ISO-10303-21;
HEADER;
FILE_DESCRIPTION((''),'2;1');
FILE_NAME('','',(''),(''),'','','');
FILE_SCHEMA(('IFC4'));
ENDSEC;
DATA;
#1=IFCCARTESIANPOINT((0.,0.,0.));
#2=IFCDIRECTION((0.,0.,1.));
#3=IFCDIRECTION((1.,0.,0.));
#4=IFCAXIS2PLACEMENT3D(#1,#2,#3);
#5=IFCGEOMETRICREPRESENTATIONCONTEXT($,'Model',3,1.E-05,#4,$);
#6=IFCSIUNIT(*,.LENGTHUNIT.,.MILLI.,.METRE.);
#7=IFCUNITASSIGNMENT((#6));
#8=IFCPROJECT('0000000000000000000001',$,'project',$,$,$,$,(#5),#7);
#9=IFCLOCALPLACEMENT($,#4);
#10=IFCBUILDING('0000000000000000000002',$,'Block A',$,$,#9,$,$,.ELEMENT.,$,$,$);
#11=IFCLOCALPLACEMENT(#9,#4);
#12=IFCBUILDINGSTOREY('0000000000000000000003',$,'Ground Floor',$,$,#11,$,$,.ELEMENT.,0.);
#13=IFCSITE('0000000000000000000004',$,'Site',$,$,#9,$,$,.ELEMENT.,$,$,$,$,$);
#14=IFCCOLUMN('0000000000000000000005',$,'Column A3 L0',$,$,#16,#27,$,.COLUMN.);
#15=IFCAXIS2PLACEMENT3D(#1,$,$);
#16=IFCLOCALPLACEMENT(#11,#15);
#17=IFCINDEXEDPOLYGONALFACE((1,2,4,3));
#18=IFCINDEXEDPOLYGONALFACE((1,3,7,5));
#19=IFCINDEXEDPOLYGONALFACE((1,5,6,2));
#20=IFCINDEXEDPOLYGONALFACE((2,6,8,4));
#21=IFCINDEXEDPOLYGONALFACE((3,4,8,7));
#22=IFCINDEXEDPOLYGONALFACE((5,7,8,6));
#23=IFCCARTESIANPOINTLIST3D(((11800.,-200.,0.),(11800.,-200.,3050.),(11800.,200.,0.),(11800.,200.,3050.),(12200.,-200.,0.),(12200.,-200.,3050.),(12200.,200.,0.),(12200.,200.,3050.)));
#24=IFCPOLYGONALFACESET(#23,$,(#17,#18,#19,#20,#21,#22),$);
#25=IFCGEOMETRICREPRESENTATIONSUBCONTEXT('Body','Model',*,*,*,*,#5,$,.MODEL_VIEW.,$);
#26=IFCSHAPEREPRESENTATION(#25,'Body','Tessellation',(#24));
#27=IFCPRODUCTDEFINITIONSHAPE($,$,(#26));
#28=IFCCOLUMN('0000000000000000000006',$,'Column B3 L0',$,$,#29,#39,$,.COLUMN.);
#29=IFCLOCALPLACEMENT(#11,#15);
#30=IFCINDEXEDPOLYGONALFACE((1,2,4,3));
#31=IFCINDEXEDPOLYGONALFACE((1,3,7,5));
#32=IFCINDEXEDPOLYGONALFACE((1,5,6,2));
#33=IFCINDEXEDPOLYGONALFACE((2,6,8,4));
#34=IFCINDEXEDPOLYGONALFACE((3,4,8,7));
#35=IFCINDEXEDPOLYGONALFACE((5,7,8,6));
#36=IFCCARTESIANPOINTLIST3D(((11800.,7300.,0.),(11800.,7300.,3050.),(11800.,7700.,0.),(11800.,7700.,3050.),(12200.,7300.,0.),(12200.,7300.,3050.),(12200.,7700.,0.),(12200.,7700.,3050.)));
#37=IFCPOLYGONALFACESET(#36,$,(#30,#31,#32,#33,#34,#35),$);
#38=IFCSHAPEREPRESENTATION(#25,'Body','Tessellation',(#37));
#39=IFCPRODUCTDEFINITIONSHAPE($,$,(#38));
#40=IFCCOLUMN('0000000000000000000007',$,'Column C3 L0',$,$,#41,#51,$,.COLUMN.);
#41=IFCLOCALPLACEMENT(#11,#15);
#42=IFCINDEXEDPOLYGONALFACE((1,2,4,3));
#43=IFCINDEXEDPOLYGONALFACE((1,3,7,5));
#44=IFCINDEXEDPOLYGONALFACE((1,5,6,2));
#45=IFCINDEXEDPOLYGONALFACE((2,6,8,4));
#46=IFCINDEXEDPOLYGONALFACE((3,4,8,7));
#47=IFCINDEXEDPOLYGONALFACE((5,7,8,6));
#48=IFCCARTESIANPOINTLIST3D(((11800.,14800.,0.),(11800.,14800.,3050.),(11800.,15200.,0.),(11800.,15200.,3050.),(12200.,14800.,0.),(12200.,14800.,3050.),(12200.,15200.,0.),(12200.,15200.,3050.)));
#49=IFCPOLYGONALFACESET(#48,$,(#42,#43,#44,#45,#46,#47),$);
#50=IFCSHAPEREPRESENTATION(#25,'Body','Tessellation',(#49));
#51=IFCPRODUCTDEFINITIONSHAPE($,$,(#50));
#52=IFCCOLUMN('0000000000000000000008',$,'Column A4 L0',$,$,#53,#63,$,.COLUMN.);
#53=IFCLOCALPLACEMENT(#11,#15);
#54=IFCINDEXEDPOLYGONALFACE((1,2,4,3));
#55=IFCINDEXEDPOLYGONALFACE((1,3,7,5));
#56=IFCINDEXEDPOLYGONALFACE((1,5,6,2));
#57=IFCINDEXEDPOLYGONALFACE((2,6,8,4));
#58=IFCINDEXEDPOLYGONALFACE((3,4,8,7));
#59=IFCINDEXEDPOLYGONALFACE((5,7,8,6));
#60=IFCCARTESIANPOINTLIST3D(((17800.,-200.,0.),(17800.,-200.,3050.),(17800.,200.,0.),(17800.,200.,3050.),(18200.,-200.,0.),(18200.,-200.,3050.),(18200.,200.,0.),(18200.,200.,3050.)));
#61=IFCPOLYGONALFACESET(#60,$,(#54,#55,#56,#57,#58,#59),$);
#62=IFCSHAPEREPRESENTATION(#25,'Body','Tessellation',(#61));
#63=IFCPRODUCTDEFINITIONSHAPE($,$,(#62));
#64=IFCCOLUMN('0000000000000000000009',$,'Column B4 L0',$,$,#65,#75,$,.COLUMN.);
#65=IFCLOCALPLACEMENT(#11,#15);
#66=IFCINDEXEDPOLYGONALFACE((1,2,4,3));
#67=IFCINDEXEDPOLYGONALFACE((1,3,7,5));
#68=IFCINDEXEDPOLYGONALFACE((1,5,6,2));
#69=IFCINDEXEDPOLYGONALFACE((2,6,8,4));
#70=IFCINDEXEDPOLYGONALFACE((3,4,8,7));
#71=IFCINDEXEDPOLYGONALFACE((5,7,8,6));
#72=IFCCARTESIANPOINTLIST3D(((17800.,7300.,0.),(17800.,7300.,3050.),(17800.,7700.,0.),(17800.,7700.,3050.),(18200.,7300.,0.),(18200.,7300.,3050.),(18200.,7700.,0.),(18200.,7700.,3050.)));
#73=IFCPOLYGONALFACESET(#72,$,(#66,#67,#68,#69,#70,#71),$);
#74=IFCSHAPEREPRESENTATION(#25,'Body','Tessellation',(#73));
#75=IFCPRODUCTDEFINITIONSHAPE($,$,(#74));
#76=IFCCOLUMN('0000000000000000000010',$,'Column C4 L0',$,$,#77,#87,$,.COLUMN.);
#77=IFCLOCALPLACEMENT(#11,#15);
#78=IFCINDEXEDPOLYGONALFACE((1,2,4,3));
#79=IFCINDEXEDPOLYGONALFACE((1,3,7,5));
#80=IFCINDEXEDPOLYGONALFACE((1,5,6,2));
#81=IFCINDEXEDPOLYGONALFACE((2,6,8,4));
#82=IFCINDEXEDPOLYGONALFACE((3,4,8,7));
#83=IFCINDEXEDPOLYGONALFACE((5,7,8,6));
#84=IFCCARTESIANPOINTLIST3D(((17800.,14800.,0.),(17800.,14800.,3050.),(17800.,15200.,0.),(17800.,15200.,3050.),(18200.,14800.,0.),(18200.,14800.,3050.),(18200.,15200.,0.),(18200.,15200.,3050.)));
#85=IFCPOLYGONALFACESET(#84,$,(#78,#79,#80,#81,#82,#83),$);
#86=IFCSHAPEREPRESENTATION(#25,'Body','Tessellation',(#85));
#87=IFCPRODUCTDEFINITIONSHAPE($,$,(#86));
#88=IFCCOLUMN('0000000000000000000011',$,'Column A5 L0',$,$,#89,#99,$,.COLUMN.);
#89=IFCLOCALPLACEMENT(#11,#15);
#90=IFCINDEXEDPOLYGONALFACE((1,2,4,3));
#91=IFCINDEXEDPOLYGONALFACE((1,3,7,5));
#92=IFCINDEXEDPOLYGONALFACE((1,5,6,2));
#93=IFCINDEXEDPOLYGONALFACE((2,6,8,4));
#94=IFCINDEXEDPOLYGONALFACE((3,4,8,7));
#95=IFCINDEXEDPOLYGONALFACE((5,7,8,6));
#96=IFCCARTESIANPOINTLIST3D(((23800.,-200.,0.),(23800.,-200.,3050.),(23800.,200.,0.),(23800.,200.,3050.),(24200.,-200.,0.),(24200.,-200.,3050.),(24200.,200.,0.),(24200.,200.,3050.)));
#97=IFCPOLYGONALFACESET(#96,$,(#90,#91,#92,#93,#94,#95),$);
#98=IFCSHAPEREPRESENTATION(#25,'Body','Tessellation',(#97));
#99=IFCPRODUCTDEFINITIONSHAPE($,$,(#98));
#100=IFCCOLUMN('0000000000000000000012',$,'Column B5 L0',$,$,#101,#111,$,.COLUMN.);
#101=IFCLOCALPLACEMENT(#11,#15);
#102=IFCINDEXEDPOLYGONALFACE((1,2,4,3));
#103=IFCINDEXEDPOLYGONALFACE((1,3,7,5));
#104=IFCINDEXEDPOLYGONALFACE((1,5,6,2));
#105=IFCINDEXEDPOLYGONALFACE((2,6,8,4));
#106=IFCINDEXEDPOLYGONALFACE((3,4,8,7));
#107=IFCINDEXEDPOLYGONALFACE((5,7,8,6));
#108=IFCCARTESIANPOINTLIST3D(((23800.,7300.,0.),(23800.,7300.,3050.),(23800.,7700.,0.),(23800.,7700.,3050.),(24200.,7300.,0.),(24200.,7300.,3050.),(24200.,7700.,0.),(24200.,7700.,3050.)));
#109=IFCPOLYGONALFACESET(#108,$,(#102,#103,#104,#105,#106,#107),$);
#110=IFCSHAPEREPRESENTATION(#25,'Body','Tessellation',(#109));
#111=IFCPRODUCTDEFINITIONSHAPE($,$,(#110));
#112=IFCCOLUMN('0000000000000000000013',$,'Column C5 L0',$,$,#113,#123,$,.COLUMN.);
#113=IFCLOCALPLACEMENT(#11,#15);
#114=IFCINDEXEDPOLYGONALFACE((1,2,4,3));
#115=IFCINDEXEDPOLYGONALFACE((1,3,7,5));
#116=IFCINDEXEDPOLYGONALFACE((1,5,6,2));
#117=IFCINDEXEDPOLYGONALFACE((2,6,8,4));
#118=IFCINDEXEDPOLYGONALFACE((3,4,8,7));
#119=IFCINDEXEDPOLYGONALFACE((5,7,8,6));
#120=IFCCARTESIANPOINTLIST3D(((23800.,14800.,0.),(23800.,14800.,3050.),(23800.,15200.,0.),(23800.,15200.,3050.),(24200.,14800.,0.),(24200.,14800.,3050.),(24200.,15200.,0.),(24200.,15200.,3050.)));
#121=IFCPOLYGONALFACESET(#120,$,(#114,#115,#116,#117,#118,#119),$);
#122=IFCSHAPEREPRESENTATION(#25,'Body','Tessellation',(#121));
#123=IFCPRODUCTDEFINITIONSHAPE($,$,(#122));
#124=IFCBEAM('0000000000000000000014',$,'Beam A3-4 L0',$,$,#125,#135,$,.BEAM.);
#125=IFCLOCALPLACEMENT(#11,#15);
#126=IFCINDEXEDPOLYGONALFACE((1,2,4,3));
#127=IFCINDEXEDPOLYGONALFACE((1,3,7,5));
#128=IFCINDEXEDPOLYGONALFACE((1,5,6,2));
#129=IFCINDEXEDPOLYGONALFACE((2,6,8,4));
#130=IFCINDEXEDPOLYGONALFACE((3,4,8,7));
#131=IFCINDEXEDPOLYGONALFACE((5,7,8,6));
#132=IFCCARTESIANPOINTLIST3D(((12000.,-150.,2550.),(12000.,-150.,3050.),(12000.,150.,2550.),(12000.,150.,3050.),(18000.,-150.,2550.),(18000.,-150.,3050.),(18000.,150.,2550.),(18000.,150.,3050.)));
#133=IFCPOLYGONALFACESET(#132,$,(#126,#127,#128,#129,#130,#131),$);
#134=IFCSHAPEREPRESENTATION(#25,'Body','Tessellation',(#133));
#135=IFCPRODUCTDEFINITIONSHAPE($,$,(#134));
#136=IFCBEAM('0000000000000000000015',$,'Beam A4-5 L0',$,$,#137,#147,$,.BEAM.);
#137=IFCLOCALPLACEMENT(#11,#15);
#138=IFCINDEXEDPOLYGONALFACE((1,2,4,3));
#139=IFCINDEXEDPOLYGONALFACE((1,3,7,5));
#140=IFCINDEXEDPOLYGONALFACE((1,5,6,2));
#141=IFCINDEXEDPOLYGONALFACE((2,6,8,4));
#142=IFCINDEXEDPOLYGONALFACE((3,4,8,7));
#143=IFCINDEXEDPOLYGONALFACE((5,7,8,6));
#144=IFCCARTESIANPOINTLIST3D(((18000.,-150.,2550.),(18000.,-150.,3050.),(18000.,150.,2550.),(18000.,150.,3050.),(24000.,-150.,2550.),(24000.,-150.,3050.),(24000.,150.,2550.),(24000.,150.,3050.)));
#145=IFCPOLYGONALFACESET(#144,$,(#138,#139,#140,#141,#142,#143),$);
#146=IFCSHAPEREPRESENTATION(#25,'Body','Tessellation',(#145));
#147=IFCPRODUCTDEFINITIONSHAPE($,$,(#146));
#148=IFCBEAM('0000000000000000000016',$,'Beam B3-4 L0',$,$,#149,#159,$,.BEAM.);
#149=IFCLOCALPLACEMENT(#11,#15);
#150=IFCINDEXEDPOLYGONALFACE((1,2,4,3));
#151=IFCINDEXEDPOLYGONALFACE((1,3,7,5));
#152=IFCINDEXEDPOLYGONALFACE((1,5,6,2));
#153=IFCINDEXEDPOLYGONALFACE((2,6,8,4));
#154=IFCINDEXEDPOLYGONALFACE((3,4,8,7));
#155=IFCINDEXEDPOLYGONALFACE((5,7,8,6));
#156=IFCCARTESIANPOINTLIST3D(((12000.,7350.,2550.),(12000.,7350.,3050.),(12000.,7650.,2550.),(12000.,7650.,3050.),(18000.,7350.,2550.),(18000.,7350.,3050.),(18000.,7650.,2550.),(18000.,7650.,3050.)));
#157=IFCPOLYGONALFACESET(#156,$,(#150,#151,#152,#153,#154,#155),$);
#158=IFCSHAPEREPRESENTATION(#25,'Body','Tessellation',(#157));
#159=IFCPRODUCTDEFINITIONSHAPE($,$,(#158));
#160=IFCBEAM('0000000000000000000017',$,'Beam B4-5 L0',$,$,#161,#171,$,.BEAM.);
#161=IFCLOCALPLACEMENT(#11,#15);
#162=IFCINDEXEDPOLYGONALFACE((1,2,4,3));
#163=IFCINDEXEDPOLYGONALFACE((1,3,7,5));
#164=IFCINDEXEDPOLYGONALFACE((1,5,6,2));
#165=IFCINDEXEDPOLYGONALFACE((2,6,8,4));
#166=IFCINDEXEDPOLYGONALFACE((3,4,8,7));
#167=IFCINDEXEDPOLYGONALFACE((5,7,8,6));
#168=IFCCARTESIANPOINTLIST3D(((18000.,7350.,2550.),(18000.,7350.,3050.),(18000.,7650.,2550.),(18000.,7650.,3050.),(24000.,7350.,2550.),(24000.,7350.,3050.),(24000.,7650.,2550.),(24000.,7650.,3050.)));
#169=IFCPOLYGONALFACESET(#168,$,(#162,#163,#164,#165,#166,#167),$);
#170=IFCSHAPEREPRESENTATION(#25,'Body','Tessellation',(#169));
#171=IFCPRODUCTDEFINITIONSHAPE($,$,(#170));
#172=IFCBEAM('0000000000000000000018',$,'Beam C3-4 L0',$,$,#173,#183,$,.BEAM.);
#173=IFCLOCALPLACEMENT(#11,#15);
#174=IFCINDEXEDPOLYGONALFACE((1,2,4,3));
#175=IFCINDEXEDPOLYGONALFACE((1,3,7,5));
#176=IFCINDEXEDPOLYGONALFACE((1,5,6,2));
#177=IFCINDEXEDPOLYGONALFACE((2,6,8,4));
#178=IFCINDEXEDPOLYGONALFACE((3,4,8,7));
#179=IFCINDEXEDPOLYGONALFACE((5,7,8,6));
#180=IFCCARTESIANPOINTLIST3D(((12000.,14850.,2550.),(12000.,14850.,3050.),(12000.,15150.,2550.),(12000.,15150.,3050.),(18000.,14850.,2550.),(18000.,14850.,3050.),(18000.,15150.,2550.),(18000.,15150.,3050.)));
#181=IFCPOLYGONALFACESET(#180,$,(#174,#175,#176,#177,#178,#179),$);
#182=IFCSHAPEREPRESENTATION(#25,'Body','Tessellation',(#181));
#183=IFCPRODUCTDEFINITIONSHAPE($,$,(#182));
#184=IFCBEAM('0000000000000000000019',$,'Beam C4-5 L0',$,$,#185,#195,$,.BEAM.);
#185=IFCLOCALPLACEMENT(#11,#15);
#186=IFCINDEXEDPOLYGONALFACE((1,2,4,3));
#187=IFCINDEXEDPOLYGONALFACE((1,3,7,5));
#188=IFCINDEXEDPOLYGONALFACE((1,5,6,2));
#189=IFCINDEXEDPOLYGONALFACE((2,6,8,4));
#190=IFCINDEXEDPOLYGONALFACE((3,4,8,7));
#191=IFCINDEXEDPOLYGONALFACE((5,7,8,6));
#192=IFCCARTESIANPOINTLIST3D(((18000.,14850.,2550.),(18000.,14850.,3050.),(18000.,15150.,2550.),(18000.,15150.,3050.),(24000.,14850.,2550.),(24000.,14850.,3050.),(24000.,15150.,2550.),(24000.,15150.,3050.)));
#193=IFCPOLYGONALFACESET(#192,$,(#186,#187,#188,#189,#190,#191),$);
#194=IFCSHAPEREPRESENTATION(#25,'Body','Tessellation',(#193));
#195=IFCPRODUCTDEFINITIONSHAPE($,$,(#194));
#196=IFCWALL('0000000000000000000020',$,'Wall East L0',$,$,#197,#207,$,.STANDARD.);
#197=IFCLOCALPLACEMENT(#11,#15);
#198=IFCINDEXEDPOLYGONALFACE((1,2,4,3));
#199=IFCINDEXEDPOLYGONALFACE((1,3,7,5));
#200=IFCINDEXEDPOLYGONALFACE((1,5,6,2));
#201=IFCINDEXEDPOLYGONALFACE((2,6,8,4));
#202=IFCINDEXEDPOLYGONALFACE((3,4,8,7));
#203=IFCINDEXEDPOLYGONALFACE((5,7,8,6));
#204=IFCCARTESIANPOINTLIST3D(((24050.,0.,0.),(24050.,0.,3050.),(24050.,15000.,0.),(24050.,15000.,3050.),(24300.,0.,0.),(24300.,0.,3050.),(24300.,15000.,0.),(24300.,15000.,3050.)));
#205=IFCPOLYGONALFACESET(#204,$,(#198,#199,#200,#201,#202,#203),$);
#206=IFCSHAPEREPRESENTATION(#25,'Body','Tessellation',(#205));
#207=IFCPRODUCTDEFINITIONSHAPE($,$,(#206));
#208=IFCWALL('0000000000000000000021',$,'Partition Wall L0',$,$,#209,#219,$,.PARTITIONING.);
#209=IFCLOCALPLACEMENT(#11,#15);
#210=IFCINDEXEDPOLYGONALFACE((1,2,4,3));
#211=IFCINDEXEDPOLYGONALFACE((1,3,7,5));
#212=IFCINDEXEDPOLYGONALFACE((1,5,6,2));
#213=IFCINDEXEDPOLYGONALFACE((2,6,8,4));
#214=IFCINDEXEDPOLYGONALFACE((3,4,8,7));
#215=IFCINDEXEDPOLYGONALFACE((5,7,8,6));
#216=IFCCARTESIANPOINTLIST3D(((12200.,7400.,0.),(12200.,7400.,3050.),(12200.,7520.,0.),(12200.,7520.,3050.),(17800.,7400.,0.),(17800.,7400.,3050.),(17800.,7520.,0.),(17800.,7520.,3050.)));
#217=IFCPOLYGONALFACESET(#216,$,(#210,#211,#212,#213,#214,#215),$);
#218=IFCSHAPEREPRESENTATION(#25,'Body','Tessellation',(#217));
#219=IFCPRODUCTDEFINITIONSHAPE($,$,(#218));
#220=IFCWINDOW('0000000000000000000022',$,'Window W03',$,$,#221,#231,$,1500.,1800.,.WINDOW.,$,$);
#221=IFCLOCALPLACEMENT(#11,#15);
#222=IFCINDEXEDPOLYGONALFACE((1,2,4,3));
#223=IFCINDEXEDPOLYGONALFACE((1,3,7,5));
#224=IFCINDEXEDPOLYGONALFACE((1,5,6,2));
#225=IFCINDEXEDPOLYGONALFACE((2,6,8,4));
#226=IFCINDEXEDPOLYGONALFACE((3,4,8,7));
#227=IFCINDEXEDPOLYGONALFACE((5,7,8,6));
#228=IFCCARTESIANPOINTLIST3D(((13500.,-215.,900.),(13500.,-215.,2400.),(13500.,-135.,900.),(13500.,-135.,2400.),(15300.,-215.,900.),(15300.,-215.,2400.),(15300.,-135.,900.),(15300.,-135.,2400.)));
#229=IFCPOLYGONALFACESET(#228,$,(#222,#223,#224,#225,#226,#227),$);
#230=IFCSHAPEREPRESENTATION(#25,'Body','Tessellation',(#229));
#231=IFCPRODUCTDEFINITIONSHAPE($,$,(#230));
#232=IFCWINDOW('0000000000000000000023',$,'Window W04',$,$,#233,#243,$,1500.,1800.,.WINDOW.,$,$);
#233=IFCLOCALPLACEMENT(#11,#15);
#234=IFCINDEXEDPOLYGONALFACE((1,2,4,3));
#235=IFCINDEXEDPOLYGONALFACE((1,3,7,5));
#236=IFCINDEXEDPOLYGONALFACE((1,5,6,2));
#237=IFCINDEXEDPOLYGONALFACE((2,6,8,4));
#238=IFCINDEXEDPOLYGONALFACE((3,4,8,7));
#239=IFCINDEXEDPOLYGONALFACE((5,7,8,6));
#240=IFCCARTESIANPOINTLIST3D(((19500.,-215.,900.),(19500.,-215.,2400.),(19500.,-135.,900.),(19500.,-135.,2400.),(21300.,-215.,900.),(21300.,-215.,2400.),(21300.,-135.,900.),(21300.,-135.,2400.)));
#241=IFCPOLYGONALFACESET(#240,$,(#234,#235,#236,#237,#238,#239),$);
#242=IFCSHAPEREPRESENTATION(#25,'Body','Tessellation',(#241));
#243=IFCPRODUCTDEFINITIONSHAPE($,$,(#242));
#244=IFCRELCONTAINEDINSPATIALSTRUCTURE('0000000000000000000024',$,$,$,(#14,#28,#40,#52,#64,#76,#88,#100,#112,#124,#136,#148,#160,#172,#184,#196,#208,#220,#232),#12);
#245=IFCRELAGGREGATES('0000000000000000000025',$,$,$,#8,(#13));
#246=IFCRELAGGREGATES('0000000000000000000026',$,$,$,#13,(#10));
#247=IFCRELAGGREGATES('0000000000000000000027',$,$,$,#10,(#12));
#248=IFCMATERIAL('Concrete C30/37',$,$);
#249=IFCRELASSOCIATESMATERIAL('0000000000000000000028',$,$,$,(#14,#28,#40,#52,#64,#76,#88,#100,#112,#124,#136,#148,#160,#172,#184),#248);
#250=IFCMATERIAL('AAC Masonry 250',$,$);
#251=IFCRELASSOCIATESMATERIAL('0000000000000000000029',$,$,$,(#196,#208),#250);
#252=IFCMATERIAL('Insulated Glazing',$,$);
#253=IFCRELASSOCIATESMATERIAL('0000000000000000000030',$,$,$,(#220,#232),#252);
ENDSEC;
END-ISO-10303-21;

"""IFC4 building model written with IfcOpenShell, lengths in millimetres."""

from ifc_helpers import new_model, si_unit, frame, frame_2d, origin_with_axes, origin_2d, place, context, subcontext, project, spatial, rectangle, extrude, material, element, save


model = new_model("IFC4")

# Units and contexts
model_context = context("Model", 3, precision=1e-05, world=origin_with_axes())
body_context = subcontext(model_context, "Body", "Model", "MODEL_VIEW")
ifc_project = project(units=[si_unit("LENGTHUNIT", "METRE", prefix="MILLI")], contexts=[model_context])

# Site, building, storey
placement = place(None, origin_with_axes())
site = spatial("IfcSite", under=ifc_project, at=placement, Name="Site", CompositionType="ELEMENT")
building = spatial("IfcBuilding", under=site, at=placement, Name="Block A", CompositionType="ELEMENT")
storey_placement = place(placement, origin_with_axes())
storey = spatial("IfcBuildingStorey", under=building, at=storey_placement, Name="Ground Floor", CompositionType="ELEMENT", Elevation=0.0)

# Columns
ifc_material_1 = material(Name="Concrete C30/37")
for number, where, z_axis, x_axis, name in (
    (1, (12000.0, 0.0, 0.0), (0.0, 0.0, 1.0), (1.0, 0.0, 0.0), "Column A3 L0"),
    (2, (12000.0, 7500.0, 0.0), (0.0, 0.0, 1.0), (1.0, 0.0, 0.0), "Column B3 L0"),
    (3, (12000.0, 15000.0, 0.0), (0.0, 0.0, 1.0), (1.0, 0.0, 0.0), "Column C3 L0"),
    (4, (18000.0, 0.0, 0.0), (0.0, 0.0, 1.0), (1.0, 0.0, 0.0), "Column A4 L0"),
    (5, (18000.0, 7500.0, 0.0), (0.0, 0.0, 1.0), (1.0, 0.0, 0.0), "Column B4 L0"),
    (6, (18000.0, 15000.0, 0.0), (0.0, 0.0, 1.0), (1.0, 0.0, 0.0), "Column C4 L0"),
    (7, (24000.0, 0.0, 0.0), (0.0, 0.0, 1.0), (1.0, 0.0, 0.0), "Column A5 L0"),
    (8, (24000.0, 7500.0, 0.0), (0.0, 0.0, 1.0), (1.0, 0.0, 0.0), "Column B5 L0"),
    (9, (24000.0, 15000.0, 0.0), (0.0, 0.0, 1.0), (1.0, 0.0, 0.0), "Column C5 L0"),
):
    element("IfcColumn", number, at=place(placement, frame(where, z_axis=z_axis, x_axis=x_axis)), inside=storey, material=ifc_material_1, Name=name, PredefinedType="COLUMN", context=body_context, shape_type="SweptSolid", body=[
        extrude(rectangle(XDim=400.0, YDim=400.0, at=origin_2d()), origin_with_axes(), (0.0, 0.0, 1.0), 3050.0),
    ])

# Beams
for number, where, z_axis, x_axis, name in (
    (10, (12000.0, 0.0, 2550.0), (0.0, 0.0, 1.0), (1.0, 0.0, 0.0), "Beam A3-4 L0"),
    (11, (18000.0, 0.0, 2550.0), (0.0, 0.0, 1.0), (1.0, 0.0, 0.0), "Beam A4-5 L0"),
    (12, (12000.0, 7500.0, 2550.0), (0.0, 0.0, 1.0), (1.0, 0.0, 0.0), "Beam B3-4 L0"),
    (13, (18000.0, 7500.0, 2550.0), (0.0, 0.0, 1.0), (1.0, 0.0, 0.0), "Beam B4-5 L0"),
    (14, (12000.0, 15000.0, 2550.0), (0.0, 0.0, 1.0), (1.0, 0.0, 0.0), "Beam C3-4 L0"),
    (15, (18000.0, 15000.0, 2550.0), (0.0, 0.0, 1.0), (1.0, 0.0, 0.0), "Beam C4-5 L0"),
):
    element("IfcBeam", number, at=place(placement, frame(where, z_axis=z_axis, x_axis=x_axis)), inside=storey, material=ifc_material_1, Name=name, PredefinedType="BEAM", context=body_context, shape_type="SweptSolid", body=[
        extrude(rectangle(XDim=6000.0, YDim=300.0, at=frame_2d((3000.0, 0.0))), origin_with_axes(), (0.0, 0.0, 1.0), 500.0),
    ])

# Walls
ifc_material_2 = material(Name="AAC Masonry 250")
wall_1_placement = place(placement, frame((24050.0, 0.0, 0.0), z_axis=(0.0, 0.0, 1.0), x_axis=(1.0, 0.0, 0.0)))
element("IfcWall", 16, at=wall_1_placement, inside=storey, material=ifc_material_2, Name="Wall East L0", PredefinedType="STANDARD", context=body_context, shape_type="SweptSolid", body=[
    extrude(rectangle(XDim=250.0, YDim=15000.0, at=frame_2d((125.0, 7500.0))), origin_with_axes(), (0.0, 0.0, 1.0), 3050.0),
])
wall_2_placement = place(placement, frame((12200.0, 7400.0, 0.0), z_axis=(0.0, 0.0, 1.0), x_axis=(1.0, 0.0, 0.0)))
element("IfcWall", 17, at=wall_2_placement, inside=storey, material=ifc_material_2, Name="Partition Wall L0", PredefinedType="PARTITIONING", context=body_context, shape_type="SweptSolid", body=[
    extrude(rectangle(XDim=5600.0, YDim=120.0, at=frame_2d((2800.0, 60.0))), origin_with_axes(), (0.0, 0.0, 1.0), 3050.0),
])

# Windows
ifc_material_3 = material(Name="Insulated Glazing")
for number, where, z_axis, x_axis, name in (
    (18, (13500.0, -215.0, 900.0), (0.0, 0.0, 1.0), (1.0, 0.0, 0.0), "Window W03"),
    (19, (19500.0, -215.0, 900.0), (0.0, 0.0, 1.0), (1.0, 0.0, 0.0), "Window W04"),
):
    element("IfcWindow", number, at=place(placement, frame(where, z_axis=z_axis, x_axis=x_axis)), inside=storey, material=ifc_material_3, Name=name, OverallHeight=1500.0, OverallWidth=1800.0, PredefinedType="WINDOW", context=body_context, shape_type="SweptSolid", body=[
        extrude(rectangle(XDim=1800.0, YDim=80.0, at=frame_2d((900.0, 40.0))), origin_with_axes(), (0.0, 0.0, 1.0), 1500.0),
    ])

save(model, "model.ifc")
